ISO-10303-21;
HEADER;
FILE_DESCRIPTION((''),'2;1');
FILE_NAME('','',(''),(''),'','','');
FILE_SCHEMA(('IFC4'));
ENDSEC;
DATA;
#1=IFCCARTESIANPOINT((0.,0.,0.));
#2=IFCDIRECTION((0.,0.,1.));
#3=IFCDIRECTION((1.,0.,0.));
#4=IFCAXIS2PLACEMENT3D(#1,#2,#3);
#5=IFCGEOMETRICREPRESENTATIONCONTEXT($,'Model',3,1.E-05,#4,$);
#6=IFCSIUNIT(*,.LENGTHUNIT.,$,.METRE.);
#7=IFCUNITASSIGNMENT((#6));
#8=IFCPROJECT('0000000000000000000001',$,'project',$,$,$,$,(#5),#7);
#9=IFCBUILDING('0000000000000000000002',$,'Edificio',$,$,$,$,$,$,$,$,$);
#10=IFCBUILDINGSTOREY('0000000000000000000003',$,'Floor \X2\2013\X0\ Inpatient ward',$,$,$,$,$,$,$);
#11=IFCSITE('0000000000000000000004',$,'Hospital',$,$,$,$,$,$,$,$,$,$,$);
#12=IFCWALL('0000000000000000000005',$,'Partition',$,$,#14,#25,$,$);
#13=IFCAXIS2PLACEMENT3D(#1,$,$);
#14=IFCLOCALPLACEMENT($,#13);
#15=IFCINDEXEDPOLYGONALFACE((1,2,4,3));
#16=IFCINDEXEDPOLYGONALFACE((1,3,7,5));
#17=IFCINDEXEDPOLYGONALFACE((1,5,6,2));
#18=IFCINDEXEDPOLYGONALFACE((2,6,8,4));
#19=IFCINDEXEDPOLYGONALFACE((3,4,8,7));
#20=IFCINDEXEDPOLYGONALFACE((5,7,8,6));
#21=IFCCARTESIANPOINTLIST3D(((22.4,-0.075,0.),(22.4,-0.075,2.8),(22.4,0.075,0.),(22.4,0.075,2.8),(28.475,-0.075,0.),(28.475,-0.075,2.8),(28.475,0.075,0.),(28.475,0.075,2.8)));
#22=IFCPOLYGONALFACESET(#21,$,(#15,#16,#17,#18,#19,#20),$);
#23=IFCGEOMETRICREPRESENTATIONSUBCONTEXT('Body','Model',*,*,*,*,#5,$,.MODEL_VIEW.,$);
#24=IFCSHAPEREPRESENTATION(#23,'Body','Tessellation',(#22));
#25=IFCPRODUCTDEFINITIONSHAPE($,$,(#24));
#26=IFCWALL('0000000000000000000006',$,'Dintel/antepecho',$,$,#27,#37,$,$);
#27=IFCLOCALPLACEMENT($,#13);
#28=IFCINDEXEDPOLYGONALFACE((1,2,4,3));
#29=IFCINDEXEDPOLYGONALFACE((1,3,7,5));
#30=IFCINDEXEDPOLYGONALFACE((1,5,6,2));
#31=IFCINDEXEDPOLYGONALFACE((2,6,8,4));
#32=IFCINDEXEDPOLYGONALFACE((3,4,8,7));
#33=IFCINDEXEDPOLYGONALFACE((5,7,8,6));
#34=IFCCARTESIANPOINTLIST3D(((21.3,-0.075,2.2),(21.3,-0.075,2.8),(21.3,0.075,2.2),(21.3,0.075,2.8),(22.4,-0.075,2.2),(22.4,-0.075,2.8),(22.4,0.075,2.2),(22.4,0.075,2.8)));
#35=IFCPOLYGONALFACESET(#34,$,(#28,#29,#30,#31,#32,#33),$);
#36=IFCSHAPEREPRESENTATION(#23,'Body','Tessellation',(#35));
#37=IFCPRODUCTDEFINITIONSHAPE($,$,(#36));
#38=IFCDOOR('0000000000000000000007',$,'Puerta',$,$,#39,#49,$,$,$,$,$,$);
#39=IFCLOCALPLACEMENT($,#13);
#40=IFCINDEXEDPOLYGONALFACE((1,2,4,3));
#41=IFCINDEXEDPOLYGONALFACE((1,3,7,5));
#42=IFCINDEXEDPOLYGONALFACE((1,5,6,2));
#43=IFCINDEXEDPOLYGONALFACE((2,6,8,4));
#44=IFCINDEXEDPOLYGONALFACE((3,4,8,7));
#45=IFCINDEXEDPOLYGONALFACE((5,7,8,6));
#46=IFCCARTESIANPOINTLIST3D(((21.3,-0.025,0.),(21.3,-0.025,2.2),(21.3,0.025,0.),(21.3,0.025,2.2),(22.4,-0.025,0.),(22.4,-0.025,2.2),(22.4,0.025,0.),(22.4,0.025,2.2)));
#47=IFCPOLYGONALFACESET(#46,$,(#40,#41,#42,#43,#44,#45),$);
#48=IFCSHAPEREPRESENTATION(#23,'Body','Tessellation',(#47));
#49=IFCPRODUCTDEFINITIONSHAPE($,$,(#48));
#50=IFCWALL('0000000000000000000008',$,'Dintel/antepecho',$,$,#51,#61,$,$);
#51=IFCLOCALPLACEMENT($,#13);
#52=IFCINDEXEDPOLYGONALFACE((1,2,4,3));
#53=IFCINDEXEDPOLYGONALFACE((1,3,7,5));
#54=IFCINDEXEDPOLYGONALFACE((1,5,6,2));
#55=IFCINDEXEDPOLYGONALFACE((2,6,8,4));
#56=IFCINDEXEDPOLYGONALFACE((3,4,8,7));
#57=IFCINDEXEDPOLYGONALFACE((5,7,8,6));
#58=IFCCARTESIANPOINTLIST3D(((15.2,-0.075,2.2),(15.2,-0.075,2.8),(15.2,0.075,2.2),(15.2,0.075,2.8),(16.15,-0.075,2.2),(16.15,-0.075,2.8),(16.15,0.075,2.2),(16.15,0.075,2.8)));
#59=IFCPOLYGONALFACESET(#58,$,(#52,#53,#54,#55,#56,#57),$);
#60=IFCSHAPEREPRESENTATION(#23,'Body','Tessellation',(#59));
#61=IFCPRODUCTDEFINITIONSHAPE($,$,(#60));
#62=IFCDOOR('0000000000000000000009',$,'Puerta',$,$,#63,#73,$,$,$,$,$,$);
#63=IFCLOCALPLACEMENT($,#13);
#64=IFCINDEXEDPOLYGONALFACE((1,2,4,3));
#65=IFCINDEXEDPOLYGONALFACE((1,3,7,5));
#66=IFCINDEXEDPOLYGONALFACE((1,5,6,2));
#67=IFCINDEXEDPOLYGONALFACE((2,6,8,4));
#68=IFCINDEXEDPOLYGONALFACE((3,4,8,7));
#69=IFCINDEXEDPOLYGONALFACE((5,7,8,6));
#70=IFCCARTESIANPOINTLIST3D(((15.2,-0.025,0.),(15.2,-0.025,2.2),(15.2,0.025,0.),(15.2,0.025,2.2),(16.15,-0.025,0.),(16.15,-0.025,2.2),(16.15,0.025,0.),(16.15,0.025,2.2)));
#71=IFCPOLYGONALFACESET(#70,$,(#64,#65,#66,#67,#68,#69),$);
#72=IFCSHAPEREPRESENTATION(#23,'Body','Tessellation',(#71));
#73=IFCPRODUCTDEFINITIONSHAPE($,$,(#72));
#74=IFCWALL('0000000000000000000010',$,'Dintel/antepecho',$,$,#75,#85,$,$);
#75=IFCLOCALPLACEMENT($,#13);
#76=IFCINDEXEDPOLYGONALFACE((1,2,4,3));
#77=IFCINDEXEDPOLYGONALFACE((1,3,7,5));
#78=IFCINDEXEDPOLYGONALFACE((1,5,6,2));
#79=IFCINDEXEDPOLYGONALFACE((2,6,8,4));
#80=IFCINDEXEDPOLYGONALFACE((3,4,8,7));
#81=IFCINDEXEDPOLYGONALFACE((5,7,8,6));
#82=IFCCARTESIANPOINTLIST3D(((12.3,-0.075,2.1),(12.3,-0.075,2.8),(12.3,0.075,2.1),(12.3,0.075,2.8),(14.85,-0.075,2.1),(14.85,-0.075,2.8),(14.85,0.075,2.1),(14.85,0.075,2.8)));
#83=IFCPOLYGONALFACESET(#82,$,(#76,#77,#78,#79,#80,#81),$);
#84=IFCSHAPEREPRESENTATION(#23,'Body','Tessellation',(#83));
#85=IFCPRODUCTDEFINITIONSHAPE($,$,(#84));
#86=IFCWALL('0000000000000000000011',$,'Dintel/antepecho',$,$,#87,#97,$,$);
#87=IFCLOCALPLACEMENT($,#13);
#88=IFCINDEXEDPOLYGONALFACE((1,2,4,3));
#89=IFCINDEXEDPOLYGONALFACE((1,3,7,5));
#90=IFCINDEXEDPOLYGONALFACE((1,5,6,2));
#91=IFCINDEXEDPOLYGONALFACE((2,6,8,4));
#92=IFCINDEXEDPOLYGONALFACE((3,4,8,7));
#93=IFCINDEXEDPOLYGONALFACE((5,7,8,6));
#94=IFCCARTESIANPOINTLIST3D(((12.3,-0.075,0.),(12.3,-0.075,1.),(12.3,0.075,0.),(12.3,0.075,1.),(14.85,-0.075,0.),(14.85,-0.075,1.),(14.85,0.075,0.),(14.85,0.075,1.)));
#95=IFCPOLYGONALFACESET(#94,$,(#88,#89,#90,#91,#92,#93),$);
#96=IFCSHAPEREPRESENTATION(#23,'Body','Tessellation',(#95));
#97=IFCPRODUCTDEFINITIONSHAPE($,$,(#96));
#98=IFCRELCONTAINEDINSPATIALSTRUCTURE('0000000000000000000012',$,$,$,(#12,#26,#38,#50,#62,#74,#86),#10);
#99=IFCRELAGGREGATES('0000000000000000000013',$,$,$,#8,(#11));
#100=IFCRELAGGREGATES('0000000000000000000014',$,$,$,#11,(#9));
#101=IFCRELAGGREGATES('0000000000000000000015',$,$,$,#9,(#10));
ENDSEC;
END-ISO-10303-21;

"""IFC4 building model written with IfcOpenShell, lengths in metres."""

from ifc_helpers import new_model, si_unit, frame, origin_with_axes, context, subcontext, project, spatial, line, indexed_curve, outline, extrude, element, save


model = new_model("IFC4")

# Units and contexts
model_context = context("Model", 3, precision=1e-05, world=origin_with_axes())
body_context = subcontext(model_context, "Body", "Model", "MODEL_VIEW")
ifc_project = project(units=[si_unit("LENGTHUNIT", "METRE")], contexts=[model_context])

# Site, building, storey
site = spatial("IfcSite", under=ifc_project, Name="Hospital")
building = spatial("IfcBuilding", under=site, Name="Edificio")
storey = spatial("IfcBuildingStorey", under=building, Name="Floor – Inpatient ward")

# Walls
element("IfcWall", 1, inside=storey, Name="Partition", context=body_context, shape_type="SweptSolid", body=[
    extrude(outline(indexed_curve([(0.0, 0.0), (6.075, 0.0), (6.075, 0.15), (0.0, 0.15)], segments=[line(1, 2, 3, 4, 1)])), frame((22.4, -0.075, 0.0), z_axis=(0.0, 0.0, 1.0), x_axis=(1.0, 0.0, 0.0)), (0.0, 0.0, 1.0), 2.8),
])
element("IfcWall", 2, inside=storey, Name="Dintel/antepecho", context=body_context, shape_type="SweptSolid", body=[
    extrude(outline(indexed_curve([(0.0, 0.0), (1.1, 0.0), (1.1, 0.15), (0.0, 0.15)], segments=[line(1, 2, 3, 4, 1)])), frame((21.3, -0.075, 2.2), z_axis=(0.0, 0.0, 1.0), x_axis=(1.0, 0.0, 0.0)), (0.0, 0.0, 1.0), 0.6),
])

# Door
element("IfcDoor", 3, inside=storey, Name="Puerta", context=body_context, shape_type="SweptSolid", body=[
    extrude(outline(indexed_curve([(0.0, 0.0), (1.1, 0.0), (1.1, 0.05), (0.0, 0.05)], segments=[line(1, 2, 3, 4, 1)])), frame((21.3, -0.025, 0.0), z_axis=(0.0, 0.0, 1.0), x_axis=(1.0, 0.0, 0.0)), (0.0, 0.0, 1.0), 2.2),
])

# Wall
element("IfcWall", 4, inside=storey, Name="Dintel/antepecho", context=body_context, shape_type="SweptSolid", body=[
    extrude(outline(indexed_curve([(0.0, 0.0), (0.95, 0.0), (0.95, 0.15), (0.0, 0.15)], segments=[line(1, 2, 3, 4, 1)])), frame((15.2, -0.075, 2.2), z_axis=(0.0, 0.0, 1.0), x_axis=(1.0, 0.0, 0.0)), (0.0, 0.0, 1.0), 0.6),
])

# Door
element("IfcDoor", 5, inside=storey, Name="Puerta", context=body_context, shape_type="SweptSolid", body=[
    extrude(outline(indexed_curve([(0.0, 0.0), (0.95, 0.0), (0.95, 0.05), (0.0, 0.05)], segments=[line(1, 2, 3, 4, 1)])), frame((15.2, -0.025, 0.0), z_axis=(0.0, 0.0, 1.0), x_axis=(1.0, 0.0, 0.0)), (0.0, 0.0, 1.0), 2.2),
])

# Walls
element("IfcWall", 6, inside=storey, Name="Dintel/antepecho", context=body_context, shape_type="SweptSolid", body=[
    extrude(outline(indexed_curve([(0.0, 0.0), (2.55, 0.0), (2.55, 0.15), (0.0, 0.15)], segments=[line(1, 2, 3, 4, 1)])), frame((12.3, -0.075, 2.1), z_axis=(0.0, 0.0, 1.0), x_axis=(1.0, 0.0, 0.0)), (0.0, 0.0, 1.0), 0.7),
])
element("IfcWall", 7, inside=storey, Name="Dintel/antepecho", context=body_context, shape_type="SweptSolid", body=[
    extrude(outline(indexed_curve([(0.0, 0.0), (2.55, 0.0), (2.55, 0.15), (0.0, 0.15)], segments=[line(1, 2, 3, 4, 1)])), frame((12.3, -0.075, 0.0), z_axis=(0.0, 0.0, 1.0), x_axis=(1.0, 0.0, 0.0)), (0.0, 0.0, 1.0), 1.0),
])

save(model, "model.ifc")
